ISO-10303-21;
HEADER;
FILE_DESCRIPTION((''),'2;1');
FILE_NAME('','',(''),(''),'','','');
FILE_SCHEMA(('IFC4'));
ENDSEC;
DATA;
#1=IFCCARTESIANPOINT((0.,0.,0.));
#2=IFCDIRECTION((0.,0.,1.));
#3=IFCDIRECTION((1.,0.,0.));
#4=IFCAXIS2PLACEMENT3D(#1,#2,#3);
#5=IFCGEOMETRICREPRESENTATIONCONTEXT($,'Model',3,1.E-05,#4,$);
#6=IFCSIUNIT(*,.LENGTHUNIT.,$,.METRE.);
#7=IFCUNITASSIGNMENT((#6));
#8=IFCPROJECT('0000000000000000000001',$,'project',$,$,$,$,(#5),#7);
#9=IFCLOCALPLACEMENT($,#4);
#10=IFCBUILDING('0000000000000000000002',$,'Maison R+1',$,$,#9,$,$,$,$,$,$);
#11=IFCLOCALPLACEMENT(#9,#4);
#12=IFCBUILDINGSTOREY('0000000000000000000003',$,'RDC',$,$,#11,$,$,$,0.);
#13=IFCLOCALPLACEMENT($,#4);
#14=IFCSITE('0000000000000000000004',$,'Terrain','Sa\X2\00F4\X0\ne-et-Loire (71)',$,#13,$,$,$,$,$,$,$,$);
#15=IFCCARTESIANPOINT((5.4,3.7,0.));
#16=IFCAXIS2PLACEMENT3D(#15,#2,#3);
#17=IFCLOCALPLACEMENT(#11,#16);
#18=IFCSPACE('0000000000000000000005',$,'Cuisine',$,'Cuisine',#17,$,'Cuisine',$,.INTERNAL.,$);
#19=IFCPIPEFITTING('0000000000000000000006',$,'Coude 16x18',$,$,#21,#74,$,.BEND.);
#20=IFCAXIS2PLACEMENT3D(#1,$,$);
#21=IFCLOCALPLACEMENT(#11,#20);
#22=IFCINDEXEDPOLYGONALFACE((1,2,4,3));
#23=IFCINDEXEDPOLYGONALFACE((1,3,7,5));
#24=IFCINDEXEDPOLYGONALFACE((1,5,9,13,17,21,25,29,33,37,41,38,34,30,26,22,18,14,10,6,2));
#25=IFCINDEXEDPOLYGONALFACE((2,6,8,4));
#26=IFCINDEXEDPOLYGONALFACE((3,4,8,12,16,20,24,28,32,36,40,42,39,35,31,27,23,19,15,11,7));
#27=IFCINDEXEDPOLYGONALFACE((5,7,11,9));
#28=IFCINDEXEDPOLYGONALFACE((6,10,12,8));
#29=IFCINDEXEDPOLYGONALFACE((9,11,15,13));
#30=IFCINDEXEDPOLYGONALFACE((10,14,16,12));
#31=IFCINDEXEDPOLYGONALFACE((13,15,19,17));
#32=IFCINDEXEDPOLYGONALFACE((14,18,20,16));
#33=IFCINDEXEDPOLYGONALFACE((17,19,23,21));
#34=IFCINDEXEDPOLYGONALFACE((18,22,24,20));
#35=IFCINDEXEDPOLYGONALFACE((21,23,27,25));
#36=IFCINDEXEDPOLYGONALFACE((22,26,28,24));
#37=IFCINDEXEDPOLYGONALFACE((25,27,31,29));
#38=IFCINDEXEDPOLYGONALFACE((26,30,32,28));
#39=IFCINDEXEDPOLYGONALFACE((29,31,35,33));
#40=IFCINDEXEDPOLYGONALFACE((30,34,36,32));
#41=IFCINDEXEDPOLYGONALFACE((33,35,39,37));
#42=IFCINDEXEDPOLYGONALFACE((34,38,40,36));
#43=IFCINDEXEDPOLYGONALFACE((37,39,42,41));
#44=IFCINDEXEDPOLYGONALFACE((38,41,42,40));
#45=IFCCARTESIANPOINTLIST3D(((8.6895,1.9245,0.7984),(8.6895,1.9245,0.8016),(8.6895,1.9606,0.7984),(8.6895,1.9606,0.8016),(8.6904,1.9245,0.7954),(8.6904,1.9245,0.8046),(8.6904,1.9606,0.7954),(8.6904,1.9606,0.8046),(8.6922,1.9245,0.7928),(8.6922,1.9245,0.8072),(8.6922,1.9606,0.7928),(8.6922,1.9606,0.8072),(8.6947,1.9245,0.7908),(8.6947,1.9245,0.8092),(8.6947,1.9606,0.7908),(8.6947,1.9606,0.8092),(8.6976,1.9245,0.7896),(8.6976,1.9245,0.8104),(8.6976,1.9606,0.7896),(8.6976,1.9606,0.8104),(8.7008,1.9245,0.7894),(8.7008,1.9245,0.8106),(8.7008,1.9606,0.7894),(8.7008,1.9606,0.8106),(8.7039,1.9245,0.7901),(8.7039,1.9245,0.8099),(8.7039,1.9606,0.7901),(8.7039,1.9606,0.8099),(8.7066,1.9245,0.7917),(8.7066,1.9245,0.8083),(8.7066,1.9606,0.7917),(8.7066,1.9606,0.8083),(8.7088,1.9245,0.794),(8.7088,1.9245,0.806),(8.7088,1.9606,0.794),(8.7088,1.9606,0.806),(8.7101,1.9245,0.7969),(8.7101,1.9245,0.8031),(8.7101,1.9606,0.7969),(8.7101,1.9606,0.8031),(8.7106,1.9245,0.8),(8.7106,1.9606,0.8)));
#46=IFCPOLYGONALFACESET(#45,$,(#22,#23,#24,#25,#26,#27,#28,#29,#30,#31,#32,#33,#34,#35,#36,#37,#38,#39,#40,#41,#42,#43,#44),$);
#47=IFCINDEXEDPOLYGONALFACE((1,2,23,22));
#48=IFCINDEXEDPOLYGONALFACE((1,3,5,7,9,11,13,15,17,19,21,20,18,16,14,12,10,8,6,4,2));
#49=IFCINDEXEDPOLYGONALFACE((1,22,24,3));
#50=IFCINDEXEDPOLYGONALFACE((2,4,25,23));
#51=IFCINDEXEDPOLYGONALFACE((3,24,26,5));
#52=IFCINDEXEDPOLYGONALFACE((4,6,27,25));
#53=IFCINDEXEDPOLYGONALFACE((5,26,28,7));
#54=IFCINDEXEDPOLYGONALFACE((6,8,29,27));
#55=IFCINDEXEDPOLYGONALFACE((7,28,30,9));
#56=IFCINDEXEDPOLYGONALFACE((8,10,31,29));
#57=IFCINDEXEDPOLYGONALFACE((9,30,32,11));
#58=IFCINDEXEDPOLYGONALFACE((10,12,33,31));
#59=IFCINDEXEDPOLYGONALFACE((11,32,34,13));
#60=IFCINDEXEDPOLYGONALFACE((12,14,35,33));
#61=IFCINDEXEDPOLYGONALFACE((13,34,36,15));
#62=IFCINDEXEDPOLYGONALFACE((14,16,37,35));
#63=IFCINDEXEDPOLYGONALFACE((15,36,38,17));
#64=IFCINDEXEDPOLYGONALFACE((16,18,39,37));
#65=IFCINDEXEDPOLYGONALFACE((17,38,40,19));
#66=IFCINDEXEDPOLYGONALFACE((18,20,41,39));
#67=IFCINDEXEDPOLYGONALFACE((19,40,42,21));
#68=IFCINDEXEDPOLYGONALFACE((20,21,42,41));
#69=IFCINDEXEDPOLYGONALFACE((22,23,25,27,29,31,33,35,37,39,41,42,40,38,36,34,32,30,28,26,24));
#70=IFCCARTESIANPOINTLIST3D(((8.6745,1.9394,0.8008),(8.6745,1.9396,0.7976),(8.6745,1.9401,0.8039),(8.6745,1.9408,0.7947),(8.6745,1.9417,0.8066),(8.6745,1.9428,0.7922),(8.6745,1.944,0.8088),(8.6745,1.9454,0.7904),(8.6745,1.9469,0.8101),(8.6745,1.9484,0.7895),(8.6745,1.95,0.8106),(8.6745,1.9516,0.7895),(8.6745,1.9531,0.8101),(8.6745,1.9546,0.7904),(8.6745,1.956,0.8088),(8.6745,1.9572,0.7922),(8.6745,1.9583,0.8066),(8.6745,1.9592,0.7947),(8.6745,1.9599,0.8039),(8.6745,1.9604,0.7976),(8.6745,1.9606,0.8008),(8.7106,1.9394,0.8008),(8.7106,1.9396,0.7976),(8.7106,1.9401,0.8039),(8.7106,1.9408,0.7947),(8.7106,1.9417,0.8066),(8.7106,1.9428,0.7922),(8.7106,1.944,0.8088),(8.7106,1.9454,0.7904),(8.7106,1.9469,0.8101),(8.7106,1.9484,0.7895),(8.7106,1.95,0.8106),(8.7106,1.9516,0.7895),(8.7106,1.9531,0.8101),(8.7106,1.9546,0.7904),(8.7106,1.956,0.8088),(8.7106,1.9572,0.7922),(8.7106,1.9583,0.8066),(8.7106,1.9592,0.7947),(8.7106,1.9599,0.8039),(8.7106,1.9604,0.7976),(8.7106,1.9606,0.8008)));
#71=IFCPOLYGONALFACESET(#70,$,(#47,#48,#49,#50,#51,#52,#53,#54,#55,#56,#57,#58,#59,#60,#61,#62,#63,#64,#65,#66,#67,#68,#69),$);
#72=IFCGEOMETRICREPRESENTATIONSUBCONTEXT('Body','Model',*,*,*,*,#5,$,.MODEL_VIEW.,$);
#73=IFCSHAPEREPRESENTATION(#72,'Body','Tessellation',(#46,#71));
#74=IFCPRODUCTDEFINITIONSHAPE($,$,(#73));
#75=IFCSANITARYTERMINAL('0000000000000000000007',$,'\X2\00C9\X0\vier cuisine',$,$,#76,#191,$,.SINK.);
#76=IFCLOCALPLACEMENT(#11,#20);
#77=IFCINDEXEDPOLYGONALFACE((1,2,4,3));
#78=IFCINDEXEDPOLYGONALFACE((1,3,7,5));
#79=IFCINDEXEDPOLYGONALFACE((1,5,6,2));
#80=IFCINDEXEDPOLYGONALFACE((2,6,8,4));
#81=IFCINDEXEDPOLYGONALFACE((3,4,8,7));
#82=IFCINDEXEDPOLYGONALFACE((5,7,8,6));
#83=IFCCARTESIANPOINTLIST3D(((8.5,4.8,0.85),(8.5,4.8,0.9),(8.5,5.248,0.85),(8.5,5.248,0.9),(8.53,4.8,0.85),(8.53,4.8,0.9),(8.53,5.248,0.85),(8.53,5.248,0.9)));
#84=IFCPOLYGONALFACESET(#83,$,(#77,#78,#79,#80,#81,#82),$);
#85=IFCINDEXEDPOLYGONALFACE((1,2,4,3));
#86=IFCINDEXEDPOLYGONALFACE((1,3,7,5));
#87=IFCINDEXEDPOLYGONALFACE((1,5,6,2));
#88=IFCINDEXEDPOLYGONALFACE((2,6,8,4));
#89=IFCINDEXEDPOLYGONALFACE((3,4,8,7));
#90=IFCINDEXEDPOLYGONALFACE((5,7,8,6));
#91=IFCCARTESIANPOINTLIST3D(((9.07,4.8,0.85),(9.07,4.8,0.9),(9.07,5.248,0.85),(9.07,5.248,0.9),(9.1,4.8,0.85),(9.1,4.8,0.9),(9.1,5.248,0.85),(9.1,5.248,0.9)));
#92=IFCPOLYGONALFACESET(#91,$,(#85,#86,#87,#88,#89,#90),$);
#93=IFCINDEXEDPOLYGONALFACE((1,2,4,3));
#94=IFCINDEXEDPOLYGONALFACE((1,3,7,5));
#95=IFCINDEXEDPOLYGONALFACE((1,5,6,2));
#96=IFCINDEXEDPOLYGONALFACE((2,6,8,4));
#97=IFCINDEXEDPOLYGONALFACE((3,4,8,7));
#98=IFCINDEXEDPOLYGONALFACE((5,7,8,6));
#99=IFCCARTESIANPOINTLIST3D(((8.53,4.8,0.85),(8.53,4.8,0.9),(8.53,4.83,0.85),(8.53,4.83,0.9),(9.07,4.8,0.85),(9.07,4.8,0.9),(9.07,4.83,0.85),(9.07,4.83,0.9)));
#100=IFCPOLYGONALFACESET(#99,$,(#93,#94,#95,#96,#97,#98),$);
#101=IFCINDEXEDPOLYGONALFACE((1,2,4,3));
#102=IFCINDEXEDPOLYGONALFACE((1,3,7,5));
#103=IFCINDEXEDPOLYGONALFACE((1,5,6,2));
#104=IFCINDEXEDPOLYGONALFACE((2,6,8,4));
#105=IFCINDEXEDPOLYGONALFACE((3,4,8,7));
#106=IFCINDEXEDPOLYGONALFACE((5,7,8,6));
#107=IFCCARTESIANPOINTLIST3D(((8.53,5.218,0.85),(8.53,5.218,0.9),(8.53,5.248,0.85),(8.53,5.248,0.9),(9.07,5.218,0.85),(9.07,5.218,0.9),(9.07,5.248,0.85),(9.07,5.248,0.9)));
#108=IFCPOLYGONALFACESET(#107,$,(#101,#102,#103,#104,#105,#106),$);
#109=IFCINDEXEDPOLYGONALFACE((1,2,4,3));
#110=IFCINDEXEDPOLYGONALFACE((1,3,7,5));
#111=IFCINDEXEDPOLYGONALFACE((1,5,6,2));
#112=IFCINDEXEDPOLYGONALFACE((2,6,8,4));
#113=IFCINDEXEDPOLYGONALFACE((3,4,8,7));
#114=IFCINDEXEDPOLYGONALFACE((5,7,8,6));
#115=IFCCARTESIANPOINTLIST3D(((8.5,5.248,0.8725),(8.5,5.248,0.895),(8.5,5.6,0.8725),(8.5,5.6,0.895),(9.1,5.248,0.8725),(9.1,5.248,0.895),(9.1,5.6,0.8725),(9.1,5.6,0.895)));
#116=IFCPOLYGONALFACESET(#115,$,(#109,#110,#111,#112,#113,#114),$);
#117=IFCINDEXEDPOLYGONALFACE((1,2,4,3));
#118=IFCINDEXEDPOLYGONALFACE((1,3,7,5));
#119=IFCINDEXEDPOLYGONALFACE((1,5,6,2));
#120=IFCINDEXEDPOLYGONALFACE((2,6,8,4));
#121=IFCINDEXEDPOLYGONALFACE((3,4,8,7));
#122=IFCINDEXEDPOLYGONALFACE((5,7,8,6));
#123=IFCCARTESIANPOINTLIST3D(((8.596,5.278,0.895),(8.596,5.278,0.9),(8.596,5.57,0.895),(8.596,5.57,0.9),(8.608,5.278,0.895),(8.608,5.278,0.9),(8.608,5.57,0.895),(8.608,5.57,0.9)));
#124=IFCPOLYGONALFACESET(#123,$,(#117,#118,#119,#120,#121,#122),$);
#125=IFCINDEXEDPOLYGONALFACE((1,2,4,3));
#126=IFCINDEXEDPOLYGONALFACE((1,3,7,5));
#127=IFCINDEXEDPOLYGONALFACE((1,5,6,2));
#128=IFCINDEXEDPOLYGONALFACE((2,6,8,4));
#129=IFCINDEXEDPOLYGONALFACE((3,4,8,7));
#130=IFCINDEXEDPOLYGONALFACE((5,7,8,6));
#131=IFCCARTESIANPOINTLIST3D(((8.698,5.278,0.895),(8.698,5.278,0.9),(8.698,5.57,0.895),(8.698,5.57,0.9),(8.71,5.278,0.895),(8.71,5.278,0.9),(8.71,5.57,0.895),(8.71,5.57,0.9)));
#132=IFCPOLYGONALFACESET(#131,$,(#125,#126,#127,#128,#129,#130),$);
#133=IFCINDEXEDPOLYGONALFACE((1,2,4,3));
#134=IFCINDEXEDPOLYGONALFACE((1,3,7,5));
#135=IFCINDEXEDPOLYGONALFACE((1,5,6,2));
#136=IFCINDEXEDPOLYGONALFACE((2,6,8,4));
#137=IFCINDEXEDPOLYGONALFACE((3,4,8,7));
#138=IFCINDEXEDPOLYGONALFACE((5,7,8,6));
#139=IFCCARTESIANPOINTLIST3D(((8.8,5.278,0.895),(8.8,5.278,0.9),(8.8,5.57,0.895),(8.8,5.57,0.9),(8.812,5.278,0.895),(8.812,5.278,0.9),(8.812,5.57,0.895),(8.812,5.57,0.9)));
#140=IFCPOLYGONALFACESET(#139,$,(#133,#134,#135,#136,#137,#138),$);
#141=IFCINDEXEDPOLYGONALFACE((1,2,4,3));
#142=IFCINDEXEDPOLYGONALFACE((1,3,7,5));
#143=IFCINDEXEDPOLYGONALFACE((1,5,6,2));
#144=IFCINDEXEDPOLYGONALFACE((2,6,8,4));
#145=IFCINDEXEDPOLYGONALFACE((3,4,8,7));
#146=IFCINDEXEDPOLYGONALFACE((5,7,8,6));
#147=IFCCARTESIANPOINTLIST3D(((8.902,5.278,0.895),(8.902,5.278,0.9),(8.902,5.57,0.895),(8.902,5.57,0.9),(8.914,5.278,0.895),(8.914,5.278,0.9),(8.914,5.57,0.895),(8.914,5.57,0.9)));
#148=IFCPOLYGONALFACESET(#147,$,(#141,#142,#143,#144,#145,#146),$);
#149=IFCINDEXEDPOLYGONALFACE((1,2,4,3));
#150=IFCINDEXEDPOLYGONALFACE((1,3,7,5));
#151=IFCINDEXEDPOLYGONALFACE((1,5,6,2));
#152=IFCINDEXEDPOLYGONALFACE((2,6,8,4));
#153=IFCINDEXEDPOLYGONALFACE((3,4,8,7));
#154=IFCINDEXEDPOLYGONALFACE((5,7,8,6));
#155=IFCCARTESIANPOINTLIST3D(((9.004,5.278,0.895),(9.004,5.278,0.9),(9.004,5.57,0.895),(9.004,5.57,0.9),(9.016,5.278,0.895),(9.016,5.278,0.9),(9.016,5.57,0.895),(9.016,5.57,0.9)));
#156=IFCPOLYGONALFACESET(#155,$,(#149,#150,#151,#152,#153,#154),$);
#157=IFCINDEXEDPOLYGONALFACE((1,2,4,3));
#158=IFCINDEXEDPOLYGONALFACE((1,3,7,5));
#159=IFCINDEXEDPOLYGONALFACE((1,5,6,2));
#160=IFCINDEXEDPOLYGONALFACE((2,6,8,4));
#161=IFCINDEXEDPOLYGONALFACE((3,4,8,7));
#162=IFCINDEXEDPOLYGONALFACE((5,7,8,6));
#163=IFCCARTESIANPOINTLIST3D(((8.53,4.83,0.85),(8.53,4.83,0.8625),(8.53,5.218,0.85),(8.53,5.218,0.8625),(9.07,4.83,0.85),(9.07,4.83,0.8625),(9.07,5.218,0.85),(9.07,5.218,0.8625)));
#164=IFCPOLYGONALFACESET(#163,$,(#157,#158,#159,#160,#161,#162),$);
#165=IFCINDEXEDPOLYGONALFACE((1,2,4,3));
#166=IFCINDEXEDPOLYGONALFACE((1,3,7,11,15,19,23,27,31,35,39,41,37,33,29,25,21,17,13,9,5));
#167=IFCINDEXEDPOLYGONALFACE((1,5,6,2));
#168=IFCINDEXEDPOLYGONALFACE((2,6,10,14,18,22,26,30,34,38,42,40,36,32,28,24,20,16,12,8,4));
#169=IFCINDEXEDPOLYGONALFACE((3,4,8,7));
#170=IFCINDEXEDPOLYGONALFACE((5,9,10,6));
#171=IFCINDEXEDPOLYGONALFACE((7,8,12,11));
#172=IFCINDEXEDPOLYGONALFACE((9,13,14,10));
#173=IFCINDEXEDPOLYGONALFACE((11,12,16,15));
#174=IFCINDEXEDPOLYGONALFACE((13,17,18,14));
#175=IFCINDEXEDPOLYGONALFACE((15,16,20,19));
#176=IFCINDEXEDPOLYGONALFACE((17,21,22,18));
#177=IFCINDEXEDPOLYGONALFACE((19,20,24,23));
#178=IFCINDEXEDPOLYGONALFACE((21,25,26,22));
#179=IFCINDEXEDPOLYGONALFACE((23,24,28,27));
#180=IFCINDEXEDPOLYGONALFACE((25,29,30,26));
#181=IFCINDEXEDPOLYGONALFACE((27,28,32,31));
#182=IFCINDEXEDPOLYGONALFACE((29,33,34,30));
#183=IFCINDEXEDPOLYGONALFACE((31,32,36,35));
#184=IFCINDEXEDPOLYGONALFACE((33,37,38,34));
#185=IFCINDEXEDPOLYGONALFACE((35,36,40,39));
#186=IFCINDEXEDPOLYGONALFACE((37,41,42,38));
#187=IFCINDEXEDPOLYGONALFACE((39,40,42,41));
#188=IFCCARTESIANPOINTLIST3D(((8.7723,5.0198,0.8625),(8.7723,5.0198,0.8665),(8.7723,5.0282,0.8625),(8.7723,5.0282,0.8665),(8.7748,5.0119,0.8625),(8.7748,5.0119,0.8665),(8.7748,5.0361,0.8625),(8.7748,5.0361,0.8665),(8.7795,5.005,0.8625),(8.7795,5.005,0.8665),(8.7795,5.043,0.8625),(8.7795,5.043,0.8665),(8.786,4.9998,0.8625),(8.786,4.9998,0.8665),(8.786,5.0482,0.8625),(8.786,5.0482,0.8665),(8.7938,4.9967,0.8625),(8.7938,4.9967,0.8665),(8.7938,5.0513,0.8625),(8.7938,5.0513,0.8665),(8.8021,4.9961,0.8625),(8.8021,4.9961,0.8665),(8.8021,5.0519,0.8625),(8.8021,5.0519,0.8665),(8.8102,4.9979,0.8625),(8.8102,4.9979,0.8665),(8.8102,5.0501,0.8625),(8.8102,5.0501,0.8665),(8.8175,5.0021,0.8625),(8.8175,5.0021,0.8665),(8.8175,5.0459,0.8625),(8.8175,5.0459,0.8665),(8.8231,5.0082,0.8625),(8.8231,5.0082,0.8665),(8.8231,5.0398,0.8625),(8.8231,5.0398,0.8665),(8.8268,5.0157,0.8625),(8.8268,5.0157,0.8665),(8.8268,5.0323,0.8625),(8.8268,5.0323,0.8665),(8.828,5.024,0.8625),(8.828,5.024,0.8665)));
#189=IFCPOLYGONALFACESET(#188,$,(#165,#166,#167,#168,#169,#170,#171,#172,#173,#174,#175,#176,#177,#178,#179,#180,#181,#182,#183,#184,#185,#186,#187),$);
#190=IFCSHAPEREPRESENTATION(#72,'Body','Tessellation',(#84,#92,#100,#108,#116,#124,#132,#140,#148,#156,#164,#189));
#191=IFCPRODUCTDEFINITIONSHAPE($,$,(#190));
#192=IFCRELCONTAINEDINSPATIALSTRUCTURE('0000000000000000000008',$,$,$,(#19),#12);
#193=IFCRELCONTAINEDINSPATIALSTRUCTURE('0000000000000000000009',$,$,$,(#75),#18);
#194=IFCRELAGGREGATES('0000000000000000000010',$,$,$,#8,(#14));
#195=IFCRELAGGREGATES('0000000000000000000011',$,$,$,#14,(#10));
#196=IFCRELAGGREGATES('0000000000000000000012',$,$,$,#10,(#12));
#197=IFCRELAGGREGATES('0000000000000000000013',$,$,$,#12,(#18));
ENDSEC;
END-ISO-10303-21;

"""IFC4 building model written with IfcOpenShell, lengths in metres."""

from ifc_helpers import new_model, si_unit, frame, frame_2d, origin_with_axes, place, context, subcontext, project, spatial, rectangle, circle, extrude, element, save


model = new_model("IFC4")

# Units and contexts
model_context = context("Model", 3, precision=1e-05, world=origin_with_axes())
body_context = subcontext(model_context, "Body", "Model", "MODEL_VIEW")
ifc_project = project(units=[si_unit("LENGTHUNIT", "METRE")], contexts=[model_context])

# Site, building, storey
site_placement = place(None, origin_with_axes())
site = spatial("IfcSite", under=ifc_project, at=site_placement, Name="Terrain", Description="Saône-et-Loire (71)")
building_placement = place(None, origin_with_axes())
building = spatial("IfcBuilding", under=site, at=building_placement, Name="Maison R+1")
storey_placement = place(building_placement, origin_with_axes())
storey = spatial("IfcBuildingStorey", under=building, at=storey_placement, Name="RDC", Elevation=0.0)

# Pipe fitting
for number, where, z_axis, x_axis, name in (
    (1, (8.7, 1.95, 0.8), (0.0, 0.0, 1.0), (1.0, 0.0, 0.0), "Coude 16x18"),
):
    element("IfcPipeFitting", number, at=place(storey_placement, frame(where, z_axis=z_axis, x_axis=x_axis)), inside=storey, Name=name, PredefinedType="BEND", context=body_context, shape_type="SweptSolid", body=[
        extrude(circle(Radius=0.0106), frame((0.0, 0.0106, 0.0), z_axis=(0.0, -1.0, 0.0), x_axis=(1.0, 0.0, 0.0)), (0.0, 0.0, 1.0), 0.0361),
        extrude(circle(Radius=0.0106), frame((0.0106, 0.0, 0.0), z_axis=(-1.0, 0.0, 0.0), x_axis=(0.0, 0.0, 1.0)), (0.0, 0.0, 1.0), 0.0361),
    ])

# Shared definitions
space_1_placement = place(storey_placement, frame((5.4, 3.7, 0.0), z_axis=(0.0, 0.0, 1.0), x_axis=(1.0, 0.0, 0.0)))
space_1 = spatial("IfcSpace", under=storey, at=space_1_placement, Name="Cuisine", ObjectType="Cuisine", LongName="Cuisine", PredefinedType="INTERNAL")

# Sanitary terminal
sanitary_terminal_1_placement = place(space_1_placement, frame((3.1, 1.1, 0.85), z_axis=(0.0, 0.0, 1.0), x_axis=(1.0, 0.0, 0.0)))
element("IfcSanitaryTerminal", 2, at=sanitary_terminal_1_placement, inside=space_1, Name="Évier cuisine", PredefinedType="SINK", context=body_context, shape_type="SweptSolid", body=[
    extrude(rectangle(XDim=0.03, YDim=0.448, at=frame_2d((0.015, 0.224))), origin_with_axes(), (0.0, 0.0, 1.0), 0.05),
    extrude(rectangle(XDim=0.03, YDim=0.448, at=frame_2d((0.015, 0.224))), frame((0.57, 0.0, 0.0), z_axis=(0.0, 0.0, 1.0), x_axis=(1.0, 0.0, 0.0)), (0.0, 0.0, 1.0), 0.05),
    extrude(rectangle(XDim=0.54, YDim=0.03, at=frame_2d((0.27, 0.015))), frame((0.03, 0.0, 0.0), z_axis=(0.0, 0.0, 1.0), x_axis=(1.0, 0.0, 0.0)), (0.0, 0.0, 1.0), 0.05),
    extrude(rectangle(XDim=0.54, YDim=0.03, at=frame_2d((0.27, 0.015))), frame((0.03, 0.418, 0.0), z_axis=(0.0, 0.0, 1.0), x_axis=(1.0, 0.0, 0.0)), (0.0, 0.0, 1.0), 0.05),
    extrude(rectangle(XDim=0.6, YDim=0.352, at=frame_2d((0.3, 0.176))), frame((0.0, 0.448, 0.0225), z_axis=(0.0, 0.0, 1.0), x_axis=(1.0, 0.0, 0.0)), (0.0, 0.0, 1.0), 0.0225),
    extrude(rectangle(XDim=0.012, YDim=0.292, at=frame_2d((0.006, 0.146))), frame((0.096, 0.478, 0.045), z_axis=(0.0, 0.0, 1.0), x_axis=(1.0, 0.0, 0.0)), (0.0, 0.0, 1.0), 0.005),
    extrude(rectangle(XDim=0.012, YDim=0.292, at=frame_2d((0.006, 0.146))), frame((0.198, 0.478, 0.045), z_axis=(0.0, 0.0, 1.0), x_axis=(1.0, 0.0, 0.0)), (0.0, 0.0, 1.0), 0.005),
    extrude(rectangle(XDim=0.012, YDim=0.292, at=frame_2d((0.006, 0.146))), frame((0.3, 0.478, 0.045), z_axis=(0.0, 0.0, 1.0), x_axis=(1.0, 0.0, 0.0)), (0.0, 0.0, 1.0), 0.005),
    extrude(rectangle(XDim=0.012, YDim=0.292, at=frame_2d((0.006, 0.146))), frame((0.402, 0.478, 0.045), z_axis=(0.0, 0.0, 1.0), x_axis=(1.0, 0.0, 0.0)), (0.0, 0.0, 1.0), 0.005),
    extrude(rectangle(XDim=0.012, YDim=0.292, at=frame_2d((0.006, 0.146))), frame((0.504, 0.478, 0.045), z_axis=(0.0, 0.0, 1.0), x_axis=(1.0, 0.0, 0.0)), (0.0, 0.0, 1.0), 0.005),
    extrude(rectangle(XDim=0.54, YDim=0.388, at=frame_2d((0.27, 0.194))), frame((0.03, 0.03, 0.0), z_axis=(0.0, 0.0, 1.0), x_axis=(1.0, 0.0, 0.0)), (0.0, 0.0, 1.0), 0.0125),
    extrude(circle(Radius=0.028), frame((0.3, 0.224, 0.0125), z_axis=(0.0, 0.0, 1.0), x_axis=(1.0, 0.0, 0.0)), (0.0, 0.0, 1.0), 0.004),
])

save(model, "model.ifc")
